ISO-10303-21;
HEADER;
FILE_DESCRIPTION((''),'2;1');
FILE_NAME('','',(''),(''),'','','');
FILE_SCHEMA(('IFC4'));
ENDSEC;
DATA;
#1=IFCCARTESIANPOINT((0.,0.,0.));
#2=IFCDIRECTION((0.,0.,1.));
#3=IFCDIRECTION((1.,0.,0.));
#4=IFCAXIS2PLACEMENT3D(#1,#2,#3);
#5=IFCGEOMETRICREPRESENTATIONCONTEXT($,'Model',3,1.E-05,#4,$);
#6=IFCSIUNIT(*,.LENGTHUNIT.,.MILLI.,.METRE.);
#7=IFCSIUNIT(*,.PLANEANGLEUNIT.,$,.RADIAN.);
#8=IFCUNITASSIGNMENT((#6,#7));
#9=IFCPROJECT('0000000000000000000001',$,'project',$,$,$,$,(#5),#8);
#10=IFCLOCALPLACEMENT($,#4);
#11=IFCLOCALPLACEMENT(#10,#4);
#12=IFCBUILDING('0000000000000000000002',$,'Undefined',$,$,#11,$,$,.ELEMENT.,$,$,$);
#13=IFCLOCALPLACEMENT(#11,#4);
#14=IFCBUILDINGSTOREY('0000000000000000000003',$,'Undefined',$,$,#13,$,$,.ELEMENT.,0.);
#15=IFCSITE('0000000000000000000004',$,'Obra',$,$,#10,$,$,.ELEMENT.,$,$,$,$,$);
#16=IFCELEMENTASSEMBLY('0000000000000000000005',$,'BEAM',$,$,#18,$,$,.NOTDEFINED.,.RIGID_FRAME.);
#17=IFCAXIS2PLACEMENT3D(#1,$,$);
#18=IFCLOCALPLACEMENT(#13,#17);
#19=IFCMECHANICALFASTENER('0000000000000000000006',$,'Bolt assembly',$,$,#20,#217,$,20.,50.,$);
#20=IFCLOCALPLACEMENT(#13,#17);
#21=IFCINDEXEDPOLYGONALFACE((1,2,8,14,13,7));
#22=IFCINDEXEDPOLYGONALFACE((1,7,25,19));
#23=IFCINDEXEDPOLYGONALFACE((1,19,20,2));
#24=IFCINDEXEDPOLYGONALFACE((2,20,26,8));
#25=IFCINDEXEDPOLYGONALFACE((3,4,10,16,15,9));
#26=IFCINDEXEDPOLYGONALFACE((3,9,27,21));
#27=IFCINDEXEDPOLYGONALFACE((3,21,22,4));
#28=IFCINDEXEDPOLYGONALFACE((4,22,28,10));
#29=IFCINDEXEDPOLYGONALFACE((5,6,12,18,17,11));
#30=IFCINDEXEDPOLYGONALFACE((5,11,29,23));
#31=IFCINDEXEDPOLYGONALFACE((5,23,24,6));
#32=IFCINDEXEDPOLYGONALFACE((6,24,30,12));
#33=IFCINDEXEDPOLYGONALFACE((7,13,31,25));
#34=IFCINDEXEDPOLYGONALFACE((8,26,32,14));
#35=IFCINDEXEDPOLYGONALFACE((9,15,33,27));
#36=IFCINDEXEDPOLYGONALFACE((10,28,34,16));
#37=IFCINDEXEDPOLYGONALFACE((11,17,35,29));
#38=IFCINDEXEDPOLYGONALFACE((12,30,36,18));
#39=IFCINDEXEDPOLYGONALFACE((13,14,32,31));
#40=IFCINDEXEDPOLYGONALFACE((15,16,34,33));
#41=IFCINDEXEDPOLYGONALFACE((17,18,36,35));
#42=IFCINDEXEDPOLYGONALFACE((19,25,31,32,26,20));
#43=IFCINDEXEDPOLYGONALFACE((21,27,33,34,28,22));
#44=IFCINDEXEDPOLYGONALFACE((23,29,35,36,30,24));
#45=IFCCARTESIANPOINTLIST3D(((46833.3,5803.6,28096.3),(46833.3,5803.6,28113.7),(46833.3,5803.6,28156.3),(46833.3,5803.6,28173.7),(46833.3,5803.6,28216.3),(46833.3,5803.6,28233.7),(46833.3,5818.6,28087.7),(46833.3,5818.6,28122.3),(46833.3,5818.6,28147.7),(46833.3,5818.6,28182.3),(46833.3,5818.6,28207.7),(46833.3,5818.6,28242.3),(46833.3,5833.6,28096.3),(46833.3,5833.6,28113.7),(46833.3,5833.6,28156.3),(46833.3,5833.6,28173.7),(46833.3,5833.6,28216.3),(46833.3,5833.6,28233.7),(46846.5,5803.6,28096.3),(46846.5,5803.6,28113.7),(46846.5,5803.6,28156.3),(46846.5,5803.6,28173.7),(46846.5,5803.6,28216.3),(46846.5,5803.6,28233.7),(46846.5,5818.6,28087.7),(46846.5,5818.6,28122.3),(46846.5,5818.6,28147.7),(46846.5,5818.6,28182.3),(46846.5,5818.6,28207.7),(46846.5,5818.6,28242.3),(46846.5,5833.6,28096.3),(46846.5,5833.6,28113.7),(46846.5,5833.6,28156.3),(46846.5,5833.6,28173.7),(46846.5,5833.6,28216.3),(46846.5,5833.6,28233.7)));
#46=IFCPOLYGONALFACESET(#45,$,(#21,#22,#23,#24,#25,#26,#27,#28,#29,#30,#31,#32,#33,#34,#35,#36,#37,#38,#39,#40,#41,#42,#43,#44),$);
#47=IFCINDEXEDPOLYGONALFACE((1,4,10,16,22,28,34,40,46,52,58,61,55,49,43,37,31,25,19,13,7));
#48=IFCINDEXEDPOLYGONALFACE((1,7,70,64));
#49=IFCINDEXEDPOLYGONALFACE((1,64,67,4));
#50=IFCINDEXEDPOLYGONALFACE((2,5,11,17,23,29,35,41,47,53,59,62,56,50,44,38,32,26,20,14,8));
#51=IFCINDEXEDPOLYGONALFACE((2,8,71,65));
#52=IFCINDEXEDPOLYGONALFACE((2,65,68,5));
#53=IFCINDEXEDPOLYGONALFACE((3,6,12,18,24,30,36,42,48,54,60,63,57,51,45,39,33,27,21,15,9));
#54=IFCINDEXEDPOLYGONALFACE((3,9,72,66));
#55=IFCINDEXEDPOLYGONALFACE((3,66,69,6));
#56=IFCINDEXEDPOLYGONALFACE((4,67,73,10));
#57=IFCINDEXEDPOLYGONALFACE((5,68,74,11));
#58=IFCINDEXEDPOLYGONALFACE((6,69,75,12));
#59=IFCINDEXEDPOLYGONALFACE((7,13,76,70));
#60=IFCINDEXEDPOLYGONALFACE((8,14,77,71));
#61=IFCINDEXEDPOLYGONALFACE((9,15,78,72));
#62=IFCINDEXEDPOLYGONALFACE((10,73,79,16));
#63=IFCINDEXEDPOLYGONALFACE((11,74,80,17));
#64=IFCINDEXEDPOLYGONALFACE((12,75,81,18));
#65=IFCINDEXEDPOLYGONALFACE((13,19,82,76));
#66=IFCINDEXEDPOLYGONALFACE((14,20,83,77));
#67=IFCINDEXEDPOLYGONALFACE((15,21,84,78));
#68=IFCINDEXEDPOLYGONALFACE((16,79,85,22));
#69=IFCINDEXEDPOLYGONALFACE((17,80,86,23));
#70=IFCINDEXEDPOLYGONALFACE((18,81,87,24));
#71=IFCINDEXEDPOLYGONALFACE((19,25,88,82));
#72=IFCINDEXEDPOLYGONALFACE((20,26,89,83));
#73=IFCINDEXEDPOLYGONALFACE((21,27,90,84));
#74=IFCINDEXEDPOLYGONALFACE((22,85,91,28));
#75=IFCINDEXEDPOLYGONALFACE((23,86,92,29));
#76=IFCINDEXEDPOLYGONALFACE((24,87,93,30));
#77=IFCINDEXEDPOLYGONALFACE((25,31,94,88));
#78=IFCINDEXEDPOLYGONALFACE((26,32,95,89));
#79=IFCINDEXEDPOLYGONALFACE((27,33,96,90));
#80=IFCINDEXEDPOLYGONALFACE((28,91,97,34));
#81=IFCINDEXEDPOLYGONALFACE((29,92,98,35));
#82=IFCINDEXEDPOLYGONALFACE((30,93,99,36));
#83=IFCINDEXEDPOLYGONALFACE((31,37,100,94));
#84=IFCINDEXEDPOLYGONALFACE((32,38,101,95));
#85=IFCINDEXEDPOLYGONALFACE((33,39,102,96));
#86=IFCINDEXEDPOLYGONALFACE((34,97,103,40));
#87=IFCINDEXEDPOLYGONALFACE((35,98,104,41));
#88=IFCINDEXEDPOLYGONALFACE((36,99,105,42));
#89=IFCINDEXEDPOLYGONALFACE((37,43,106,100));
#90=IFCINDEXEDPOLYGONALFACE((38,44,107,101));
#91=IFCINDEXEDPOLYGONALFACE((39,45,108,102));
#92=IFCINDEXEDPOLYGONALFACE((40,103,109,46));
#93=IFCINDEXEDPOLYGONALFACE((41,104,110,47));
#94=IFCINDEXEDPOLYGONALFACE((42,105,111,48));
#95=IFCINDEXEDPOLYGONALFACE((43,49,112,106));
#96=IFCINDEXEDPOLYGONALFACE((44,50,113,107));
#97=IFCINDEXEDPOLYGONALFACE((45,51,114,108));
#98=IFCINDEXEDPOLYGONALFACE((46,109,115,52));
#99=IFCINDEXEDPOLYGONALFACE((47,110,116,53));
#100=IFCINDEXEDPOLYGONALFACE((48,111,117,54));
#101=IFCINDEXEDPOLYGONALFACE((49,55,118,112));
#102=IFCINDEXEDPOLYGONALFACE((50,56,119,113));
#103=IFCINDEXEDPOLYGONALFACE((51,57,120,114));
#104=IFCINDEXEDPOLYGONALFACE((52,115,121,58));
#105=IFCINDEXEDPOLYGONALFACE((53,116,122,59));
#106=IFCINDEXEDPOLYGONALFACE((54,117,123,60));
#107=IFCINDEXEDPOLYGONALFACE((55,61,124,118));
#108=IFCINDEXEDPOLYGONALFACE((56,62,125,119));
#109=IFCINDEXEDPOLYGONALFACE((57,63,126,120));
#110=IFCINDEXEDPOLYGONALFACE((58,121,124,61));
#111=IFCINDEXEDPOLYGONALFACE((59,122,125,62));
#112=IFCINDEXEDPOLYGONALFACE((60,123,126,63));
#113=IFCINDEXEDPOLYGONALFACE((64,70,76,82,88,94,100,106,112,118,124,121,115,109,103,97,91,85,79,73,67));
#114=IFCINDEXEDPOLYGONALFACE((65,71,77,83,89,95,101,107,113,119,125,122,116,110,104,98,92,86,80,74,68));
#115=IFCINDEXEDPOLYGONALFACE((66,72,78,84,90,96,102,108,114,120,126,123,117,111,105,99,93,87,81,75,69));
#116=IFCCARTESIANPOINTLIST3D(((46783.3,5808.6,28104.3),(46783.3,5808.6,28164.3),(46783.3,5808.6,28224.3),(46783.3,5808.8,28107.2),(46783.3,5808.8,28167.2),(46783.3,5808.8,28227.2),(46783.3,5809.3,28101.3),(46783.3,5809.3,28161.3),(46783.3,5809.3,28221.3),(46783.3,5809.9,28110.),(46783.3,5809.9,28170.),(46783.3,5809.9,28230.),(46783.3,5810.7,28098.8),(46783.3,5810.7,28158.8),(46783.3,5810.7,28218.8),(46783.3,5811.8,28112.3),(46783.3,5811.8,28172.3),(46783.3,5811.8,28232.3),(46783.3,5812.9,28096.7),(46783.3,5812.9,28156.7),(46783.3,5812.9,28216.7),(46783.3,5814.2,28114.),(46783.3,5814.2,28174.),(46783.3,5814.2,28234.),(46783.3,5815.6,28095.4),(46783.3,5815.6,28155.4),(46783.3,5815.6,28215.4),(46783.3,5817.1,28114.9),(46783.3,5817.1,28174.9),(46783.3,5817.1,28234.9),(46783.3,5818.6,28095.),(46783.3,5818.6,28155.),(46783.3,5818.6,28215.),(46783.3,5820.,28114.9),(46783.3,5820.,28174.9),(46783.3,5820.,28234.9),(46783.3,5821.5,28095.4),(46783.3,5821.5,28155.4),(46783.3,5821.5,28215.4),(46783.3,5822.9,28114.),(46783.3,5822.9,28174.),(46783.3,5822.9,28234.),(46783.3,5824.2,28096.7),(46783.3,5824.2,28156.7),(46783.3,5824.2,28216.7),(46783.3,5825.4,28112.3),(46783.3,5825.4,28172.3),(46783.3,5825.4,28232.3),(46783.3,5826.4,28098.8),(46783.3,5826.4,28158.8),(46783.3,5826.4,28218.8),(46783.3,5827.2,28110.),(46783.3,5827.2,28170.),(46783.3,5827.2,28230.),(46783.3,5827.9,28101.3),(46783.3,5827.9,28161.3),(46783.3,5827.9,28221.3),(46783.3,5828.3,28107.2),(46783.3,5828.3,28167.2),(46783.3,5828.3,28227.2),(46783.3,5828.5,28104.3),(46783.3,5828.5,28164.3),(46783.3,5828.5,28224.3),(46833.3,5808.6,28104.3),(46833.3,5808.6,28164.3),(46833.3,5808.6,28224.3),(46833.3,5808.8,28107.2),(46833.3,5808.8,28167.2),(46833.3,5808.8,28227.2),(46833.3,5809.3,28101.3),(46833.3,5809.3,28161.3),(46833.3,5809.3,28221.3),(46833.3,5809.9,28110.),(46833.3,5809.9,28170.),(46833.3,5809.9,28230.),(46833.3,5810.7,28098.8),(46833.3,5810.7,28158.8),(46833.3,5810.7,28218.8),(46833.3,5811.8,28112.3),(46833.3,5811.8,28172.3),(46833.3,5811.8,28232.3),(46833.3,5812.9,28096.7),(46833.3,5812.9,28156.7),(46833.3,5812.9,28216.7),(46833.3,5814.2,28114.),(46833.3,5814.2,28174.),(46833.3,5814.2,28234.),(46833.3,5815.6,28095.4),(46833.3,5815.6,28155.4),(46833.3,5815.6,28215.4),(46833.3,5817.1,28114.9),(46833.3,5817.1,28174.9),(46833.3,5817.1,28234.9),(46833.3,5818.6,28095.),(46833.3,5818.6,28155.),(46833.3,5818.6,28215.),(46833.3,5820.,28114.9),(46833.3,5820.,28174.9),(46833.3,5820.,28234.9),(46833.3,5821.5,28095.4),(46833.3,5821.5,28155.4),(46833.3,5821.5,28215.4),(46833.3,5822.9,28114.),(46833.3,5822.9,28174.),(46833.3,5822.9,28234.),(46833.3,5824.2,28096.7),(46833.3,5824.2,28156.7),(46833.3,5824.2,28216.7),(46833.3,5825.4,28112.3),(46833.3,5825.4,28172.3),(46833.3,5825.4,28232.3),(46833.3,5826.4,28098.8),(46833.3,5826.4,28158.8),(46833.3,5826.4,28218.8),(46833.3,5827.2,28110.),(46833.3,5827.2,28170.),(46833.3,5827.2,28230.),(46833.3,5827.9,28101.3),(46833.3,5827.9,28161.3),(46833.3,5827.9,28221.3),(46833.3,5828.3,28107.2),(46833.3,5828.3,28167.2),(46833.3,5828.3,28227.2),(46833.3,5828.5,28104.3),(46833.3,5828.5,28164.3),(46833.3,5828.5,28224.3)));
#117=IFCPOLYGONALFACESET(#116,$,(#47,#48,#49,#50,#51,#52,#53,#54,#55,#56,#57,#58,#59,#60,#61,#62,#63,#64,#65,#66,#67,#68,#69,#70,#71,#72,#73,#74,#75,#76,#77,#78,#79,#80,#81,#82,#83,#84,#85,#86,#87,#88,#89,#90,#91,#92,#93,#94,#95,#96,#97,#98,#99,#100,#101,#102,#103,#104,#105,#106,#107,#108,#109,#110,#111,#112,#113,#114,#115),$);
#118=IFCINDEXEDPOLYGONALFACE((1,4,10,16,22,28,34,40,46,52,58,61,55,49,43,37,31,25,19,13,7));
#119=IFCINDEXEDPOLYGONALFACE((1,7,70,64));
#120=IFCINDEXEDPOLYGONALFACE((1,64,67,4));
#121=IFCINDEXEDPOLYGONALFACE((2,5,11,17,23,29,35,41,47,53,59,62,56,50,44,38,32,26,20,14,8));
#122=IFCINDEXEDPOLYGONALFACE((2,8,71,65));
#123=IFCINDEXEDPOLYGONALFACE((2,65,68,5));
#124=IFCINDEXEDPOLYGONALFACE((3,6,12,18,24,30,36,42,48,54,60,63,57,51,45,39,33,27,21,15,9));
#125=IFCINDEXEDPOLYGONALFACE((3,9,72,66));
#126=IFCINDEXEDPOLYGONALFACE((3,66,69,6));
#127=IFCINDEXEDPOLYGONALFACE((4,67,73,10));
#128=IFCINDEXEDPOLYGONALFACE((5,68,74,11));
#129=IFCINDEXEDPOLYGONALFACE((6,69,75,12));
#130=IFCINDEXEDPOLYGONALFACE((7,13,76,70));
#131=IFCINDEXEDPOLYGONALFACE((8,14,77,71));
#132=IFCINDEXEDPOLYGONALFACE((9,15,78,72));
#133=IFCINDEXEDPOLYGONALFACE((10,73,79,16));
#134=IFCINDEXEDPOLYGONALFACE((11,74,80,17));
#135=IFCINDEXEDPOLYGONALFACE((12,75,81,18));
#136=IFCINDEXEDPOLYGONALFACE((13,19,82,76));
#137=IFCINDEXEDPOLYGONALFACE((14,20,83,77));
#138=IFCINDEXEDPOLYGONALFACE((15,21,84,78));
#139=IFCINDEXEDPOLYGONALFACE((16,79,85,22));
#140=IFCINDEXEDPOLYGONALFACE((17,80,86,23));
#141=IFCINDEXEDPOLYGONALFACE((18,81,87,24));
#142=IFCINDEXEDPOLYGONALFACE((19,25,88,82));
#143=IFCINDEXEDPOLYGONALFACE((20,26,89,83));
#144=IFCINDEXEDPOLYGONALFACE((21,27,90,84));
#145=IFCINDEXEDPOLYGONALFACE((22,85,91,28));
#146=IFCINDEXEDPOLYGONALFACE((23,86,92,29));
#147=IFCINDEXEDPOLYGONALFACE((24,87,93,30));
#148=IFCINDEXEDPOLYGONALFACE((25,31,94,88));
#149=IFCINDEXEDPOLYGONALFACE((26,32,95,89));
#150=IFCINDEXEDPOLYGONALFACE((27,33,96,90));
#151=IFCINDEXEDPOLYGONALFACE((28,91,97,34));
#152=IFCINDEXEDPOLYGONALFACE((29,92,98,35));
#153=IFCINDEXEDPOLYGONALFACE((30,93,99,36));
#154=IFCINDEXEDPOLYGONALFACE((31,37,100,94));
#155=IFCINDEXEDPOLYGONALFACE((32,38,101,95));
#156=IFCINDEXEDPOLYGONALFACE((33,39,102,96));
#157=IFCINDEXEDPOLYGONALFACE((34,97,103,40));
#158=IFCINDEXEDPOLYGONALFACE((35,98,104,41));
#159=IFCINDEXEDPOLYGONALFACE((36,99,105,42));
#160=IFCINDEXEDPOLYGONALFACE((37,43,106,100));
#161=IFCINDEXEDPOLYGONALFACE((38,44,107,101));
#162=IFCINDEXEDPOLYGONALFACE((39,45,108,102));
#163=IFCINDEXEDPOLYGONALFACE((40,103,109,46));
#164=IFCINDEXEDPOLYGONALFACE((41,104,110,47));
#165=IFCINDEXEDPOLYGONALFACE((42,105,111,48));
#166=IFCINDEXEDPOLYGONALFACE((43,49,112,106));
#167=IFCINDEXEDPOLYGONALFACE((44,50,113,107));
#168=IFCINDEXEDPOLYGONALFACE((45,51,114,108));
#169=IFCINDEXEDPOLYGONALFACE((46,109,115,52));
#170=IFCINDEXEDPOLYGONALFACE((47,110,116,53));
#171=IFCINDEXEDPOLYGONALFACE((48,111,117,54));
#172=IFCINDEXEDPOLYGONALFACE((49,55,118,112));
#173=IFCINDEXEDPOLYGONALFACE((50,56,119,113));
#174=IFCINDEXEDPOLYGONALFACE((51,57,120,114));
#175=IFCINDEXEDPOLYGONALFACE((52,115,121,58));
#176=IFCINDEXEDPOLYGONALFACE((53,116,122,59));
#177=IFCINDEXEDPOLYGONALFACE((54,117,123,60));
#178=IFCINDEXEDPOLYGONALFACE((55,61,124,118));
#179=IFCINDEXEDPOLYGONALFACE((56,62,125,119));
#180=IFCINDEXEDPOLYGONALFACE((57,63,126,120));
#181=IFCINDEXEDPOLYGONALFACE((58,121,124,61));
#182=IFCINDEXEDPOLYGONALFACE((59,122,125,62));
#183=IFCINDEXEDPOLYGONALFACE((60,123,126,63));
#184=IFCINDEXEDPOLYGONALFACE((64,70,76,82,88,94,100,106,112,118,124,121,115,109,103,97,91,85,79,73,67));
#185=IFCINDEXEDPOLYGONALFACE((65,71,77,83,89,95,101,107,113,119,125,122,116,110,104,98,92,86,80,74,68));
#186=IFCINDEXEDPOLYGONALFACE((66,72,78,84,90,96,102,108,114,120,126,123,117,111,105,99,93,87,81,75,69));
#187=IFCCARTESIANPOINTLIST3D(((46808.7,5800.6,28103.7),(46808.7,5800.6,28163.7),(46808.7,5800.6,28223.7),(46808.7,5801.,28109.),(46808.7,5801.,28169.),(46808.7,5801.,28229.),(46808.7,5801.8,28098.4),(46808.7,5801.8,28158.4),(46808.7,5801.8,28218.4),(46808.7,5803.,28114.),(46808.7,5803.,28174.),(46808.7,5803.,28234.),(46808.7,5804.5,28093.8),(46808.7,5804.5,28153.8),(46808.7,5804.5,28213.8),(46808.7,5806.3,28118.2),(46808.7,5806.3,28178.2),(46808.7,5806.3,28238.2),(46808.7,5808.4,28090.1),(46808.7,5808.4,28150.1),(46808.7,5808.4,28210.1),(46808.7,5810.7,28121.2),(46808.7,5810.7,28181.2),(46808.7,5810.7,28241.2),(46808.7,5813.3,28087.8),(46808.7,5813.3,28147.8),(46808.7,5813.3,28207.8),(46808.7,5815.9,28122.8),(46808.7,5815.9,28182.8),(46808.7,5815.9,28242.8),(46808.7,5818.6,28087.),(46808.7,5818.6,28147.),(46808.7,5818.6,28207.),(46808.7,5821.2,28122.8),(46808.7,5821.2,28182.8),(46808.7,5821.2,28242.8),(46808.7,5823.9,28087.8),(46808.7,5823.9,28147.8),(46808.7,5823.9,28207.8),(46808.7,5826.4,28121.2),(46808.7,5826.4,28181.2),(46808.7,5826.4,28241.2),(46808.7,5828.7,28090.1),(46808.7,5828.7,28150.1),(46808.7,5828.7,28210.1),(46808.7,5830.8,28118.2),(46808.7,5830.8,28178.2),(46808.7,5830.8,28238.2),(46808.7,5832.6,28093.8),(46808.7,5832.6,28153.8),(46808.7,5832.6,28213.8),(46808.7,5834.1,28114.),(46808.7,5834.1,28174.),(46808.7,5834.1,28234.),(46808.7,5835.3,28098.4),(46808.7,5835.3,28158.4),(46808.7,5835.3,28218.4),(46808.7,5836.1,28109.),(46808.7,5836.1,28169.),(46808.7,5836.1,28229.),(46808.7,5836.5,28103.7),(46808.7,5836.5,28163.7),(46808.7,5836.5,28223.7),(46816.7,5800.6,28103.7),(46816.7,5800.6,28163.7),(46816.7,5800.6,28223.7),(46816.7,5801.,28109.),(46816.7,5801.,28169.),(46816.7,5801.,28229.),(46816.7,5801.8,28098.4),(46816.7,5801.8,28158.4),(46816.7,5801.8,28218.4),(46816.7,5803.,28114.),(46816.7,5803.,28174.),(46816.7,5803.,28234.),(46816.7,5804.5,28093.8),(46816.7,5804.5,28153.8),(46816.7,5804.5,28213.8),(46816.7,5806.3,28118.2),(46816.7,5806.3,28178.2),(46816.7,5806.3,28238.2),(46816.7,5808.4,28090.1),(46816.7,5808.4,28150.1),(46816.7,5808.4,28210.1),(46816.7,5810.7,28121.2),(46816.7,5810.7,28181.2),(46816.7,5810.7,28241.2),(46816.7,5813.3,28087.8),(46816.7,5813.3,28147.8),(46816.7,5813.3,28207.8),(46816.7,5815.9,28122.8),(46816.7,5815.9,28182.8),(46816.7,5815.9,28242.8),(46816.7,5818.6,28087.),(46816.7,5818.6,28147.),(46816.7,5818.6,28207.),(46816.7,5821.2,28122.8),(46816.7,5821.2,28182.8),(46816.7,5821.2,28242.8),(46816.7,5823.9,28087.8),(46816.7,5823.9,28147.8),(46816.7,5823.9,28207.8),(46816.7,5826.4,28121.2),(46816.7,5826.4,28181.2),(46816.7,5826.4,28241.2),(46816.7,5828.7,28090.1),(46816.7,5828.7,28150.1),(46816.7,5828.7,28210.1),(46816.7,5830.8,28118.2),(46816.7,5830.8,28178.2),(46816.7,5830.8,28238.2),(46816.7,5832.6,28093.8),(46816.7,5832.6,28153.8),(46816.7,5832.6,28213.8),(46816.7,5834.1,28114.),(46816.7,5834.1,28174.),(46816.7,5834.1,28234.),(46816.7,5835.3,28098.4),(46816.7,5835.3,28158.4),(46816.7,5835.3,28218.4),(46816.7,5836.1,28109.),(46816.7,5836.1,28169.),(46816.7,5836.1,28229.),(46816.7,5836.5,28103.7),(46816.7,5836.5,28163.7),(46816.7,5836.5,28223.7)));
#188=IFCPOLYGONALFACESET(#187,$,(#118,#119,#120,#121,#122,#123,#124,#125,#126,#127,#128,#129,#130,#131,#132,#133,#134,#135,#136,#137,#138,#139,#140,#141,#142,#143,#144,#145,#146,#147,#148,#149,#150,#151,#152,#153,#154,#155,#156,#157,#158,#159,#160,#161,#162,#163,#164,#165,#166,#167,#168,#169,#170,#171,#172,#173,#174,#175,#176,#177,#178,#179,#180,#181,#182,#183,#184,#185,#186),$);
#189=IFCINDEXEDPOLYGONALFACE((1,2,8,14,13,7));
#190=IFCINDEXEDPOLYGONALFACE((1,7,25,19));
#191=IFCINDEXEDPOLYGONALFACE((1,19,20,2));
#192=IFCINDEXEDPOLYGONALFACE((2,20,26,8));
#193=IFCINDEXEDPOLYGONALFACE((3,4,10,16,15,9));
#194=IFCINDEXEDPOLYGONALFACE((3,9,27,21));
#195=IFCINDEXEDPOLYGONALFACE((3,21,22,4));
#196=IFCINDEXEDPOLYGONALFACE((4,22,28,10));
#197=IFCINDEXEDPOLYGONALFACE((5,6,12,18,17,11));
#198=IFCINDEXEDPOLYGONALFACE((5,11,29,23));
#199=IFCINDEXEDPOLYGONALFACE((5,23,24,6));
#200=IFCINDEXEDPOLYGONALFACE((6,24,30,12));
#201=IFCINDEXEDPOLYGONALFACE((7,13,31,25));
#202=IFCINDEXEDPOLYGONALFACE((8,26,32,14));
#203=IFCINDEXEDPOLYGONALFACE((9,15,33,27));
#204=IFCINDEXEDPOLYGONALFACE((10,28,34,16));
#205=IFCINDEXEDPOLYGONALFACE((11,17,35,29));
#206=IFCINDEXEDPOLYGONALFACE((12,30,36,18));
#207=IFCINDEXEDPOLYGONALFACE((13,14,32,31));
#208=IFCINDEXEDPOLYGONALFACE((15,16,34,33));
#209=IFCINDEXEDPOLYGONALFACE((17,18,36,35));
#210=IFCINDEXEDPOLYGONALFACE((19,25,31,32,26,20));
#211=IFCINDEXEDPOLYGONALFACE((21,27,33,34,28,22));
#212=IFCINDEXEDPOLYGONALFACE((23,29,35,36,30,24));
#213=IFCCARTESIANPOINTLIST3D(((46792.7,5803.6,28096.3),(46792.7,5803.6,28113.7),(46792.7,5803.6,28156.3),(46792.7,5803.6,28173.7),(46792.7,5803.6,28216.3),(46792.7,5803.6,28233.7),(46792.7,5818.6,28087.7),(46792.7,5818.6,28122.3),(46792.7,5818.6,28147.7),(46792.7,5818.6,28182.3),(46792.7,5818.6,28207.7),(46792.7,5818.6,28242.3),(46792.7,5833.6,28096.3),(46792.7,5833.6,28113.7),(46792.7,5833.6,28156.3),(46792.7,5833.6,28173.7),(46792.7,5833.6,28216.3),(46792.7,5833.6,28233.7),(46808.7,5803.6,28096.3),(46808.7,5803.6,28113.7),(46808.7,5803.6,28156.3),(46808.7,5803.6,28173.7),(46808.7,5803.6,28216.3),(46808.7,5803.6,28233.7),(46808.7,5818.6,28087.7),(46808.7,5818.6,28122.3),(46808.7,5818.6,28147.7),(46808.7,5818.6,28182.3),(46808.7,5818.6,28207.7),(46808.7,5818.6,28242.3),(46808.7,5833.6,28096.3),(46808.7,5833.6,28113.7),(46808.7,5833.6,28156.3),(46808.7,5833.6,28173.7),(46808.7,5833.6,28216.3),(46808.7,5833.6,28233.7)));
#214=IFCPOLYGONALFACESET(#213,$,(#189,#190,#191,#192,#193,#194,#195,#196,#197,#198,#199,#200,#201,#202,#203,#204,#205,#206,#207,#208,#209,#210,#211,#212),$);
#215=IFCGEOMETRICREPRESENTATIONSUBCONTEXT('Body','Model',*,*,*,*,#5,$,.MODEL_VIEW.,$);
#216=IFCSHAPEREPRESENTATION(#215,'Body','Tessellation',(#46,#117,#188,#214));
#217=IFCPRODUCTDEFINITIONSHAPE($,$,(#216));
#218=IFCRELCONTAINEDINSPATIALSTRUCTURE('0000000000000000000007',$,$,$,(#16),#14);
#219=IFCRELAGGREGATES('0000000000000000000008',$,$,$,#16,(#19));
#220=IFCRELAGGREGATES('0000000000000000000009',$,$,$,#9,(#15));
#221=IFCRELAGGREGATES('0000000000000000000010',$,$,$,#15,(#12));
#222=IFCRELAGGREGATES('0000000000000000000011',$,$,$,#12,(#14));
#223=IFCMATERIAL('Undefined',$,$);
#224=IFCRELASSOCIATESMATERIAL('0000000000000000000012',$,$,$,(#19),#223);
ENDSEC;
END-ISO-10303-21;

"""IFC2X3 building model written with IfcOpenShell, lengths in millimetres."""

from ifc_helpers import new_model, si_unit, frame, origin_with_axes, origin_2d_with_axis, place, context, subcontext, project, spatial, polyline, circle, outline, extrude, source, transform, mapped, material, element, aggregate, save


model = new_model("IFC2X3")

# Units and contexts
model_context = context("Model", 3, precision=1e-05, world=origin_with_axes())
body_context = subcontext(model_context, "Body", "Model", "MODEL_VIEW")
ifc_project = project(units=[si_unit("LENGTHUNIT", "METRE", prefix="MILLI"), si_unit("PLANEANGLEUNIT", "RADIAN")], contexts=[model_context])

# Site, building, storey
site_placement = place(None, origin_with_axes())
site = spatial("IfcSite", under=ifc_project, at=site_placement, Name="Obra", CompositionType="ELEMENT")
building_placement = place(site_placement, origin_with_axes())
building = spatial("IfcBuilding", under=site, at=building_placement, Name="Undefined", CompositionType="ELEMENT")
storey_placement = place(building_placement, origin_with_axes())
storey = spatial("IfcBuildingStorey", under=building, at=storey_placement, Name="Undefined", CompositionType="ELEMENT", Elevation=0.0)

# Shared definitions
ifc_material_1 = material(Name="Undefined")

# Element assembly, mechanical fastener
shared_shape_1 = source(origin_with_axes(), body_context, "Body", "SweptSolid", [
    extrude(outline(polyline([(17.3, 0.0), (8.7, 15.0), (-8.7, 15.0), (-17.3, 0.0), (-8.7, -15.0), (8.7, -15.0), (17.3, 0.0)])), frame((0.0, -26.5, 0.0), z_axis=(0.0, 1.0, 0.0), x_axis=(1.0, 0.0, 0.0)), (0.0, 0.0, 1.0), 13.2),
    extrude(circle(Radius=10.0, at=origin_2d_with_axis()), frame((0.0, -13.3, 0.0), z_axis=(0.0, 1.0, 0.0), x_axis=(1.0, 0.0, 0.0)), (0.0, 0.0, 1.0), 50.0),
    extrude(circle(Radius=18.0, at=origin_2d_with_axis()), frame((0.0, 3.3, 0.0), z_axis=(0.0, 1.0, 0.0), x_axis=(1.0, 0.0, 0.0)), (0.0, 0.0, 1.0), 8.0),
    extrude(outline(polyline([(17.3, 0.0), (8.7, 15.0), (-8.7, 15.0), (-17.3, 0.0), (-8.7, -15.0), (8.7, -15.0), (17.3, 0.0)])), frame((0.0, 11.3, 0.0), z_axis=(0.0, 1.0, 0.0), x_axis=(1.0, 0.0, 0.0)), (0.0, 0.0, 1.0), 16.0),
])
assembly_1_placement = place(storey_placement, origin_with_axes())
assembly_1 = element("IfcElementAssembly", 1, at=assembly_1_placement, inside=storey, Name="BEAM", AssemblyPlace="NOTDEFINED", PredefinedType="RIGID_FRAME")
mechanical_fastener_1_placement = place(assembly_1_placement, frame((46820.0, 5768.6, 28265.0), z_axis=(0.0, 1.0, 0.0), x_axis=(0.0, 0.0, -1.0)))
mechanical_fastener_1 = element("IfcMechanicalFastener", 2, at=mechanical_fastener_1_placement, material=ifc_material_1, Name="Bolt assembly", NominalDiameter=20.0, NominalLength=50.0, context=body_context, shape_type="MappedRepresentation", body=[
    mapped(shared_shape_1, transform((40.0, 0.0, 50.0))),
    mapped(shared_shape_1, transform((100.0, 0.0, 50.0))),
    mapped(shared_shape_1, transform((160.0, 0.0, 50.0))),
])
aggregate(assembly_1, [mechanical_fastener_1])

save(model, "model.ifc")
